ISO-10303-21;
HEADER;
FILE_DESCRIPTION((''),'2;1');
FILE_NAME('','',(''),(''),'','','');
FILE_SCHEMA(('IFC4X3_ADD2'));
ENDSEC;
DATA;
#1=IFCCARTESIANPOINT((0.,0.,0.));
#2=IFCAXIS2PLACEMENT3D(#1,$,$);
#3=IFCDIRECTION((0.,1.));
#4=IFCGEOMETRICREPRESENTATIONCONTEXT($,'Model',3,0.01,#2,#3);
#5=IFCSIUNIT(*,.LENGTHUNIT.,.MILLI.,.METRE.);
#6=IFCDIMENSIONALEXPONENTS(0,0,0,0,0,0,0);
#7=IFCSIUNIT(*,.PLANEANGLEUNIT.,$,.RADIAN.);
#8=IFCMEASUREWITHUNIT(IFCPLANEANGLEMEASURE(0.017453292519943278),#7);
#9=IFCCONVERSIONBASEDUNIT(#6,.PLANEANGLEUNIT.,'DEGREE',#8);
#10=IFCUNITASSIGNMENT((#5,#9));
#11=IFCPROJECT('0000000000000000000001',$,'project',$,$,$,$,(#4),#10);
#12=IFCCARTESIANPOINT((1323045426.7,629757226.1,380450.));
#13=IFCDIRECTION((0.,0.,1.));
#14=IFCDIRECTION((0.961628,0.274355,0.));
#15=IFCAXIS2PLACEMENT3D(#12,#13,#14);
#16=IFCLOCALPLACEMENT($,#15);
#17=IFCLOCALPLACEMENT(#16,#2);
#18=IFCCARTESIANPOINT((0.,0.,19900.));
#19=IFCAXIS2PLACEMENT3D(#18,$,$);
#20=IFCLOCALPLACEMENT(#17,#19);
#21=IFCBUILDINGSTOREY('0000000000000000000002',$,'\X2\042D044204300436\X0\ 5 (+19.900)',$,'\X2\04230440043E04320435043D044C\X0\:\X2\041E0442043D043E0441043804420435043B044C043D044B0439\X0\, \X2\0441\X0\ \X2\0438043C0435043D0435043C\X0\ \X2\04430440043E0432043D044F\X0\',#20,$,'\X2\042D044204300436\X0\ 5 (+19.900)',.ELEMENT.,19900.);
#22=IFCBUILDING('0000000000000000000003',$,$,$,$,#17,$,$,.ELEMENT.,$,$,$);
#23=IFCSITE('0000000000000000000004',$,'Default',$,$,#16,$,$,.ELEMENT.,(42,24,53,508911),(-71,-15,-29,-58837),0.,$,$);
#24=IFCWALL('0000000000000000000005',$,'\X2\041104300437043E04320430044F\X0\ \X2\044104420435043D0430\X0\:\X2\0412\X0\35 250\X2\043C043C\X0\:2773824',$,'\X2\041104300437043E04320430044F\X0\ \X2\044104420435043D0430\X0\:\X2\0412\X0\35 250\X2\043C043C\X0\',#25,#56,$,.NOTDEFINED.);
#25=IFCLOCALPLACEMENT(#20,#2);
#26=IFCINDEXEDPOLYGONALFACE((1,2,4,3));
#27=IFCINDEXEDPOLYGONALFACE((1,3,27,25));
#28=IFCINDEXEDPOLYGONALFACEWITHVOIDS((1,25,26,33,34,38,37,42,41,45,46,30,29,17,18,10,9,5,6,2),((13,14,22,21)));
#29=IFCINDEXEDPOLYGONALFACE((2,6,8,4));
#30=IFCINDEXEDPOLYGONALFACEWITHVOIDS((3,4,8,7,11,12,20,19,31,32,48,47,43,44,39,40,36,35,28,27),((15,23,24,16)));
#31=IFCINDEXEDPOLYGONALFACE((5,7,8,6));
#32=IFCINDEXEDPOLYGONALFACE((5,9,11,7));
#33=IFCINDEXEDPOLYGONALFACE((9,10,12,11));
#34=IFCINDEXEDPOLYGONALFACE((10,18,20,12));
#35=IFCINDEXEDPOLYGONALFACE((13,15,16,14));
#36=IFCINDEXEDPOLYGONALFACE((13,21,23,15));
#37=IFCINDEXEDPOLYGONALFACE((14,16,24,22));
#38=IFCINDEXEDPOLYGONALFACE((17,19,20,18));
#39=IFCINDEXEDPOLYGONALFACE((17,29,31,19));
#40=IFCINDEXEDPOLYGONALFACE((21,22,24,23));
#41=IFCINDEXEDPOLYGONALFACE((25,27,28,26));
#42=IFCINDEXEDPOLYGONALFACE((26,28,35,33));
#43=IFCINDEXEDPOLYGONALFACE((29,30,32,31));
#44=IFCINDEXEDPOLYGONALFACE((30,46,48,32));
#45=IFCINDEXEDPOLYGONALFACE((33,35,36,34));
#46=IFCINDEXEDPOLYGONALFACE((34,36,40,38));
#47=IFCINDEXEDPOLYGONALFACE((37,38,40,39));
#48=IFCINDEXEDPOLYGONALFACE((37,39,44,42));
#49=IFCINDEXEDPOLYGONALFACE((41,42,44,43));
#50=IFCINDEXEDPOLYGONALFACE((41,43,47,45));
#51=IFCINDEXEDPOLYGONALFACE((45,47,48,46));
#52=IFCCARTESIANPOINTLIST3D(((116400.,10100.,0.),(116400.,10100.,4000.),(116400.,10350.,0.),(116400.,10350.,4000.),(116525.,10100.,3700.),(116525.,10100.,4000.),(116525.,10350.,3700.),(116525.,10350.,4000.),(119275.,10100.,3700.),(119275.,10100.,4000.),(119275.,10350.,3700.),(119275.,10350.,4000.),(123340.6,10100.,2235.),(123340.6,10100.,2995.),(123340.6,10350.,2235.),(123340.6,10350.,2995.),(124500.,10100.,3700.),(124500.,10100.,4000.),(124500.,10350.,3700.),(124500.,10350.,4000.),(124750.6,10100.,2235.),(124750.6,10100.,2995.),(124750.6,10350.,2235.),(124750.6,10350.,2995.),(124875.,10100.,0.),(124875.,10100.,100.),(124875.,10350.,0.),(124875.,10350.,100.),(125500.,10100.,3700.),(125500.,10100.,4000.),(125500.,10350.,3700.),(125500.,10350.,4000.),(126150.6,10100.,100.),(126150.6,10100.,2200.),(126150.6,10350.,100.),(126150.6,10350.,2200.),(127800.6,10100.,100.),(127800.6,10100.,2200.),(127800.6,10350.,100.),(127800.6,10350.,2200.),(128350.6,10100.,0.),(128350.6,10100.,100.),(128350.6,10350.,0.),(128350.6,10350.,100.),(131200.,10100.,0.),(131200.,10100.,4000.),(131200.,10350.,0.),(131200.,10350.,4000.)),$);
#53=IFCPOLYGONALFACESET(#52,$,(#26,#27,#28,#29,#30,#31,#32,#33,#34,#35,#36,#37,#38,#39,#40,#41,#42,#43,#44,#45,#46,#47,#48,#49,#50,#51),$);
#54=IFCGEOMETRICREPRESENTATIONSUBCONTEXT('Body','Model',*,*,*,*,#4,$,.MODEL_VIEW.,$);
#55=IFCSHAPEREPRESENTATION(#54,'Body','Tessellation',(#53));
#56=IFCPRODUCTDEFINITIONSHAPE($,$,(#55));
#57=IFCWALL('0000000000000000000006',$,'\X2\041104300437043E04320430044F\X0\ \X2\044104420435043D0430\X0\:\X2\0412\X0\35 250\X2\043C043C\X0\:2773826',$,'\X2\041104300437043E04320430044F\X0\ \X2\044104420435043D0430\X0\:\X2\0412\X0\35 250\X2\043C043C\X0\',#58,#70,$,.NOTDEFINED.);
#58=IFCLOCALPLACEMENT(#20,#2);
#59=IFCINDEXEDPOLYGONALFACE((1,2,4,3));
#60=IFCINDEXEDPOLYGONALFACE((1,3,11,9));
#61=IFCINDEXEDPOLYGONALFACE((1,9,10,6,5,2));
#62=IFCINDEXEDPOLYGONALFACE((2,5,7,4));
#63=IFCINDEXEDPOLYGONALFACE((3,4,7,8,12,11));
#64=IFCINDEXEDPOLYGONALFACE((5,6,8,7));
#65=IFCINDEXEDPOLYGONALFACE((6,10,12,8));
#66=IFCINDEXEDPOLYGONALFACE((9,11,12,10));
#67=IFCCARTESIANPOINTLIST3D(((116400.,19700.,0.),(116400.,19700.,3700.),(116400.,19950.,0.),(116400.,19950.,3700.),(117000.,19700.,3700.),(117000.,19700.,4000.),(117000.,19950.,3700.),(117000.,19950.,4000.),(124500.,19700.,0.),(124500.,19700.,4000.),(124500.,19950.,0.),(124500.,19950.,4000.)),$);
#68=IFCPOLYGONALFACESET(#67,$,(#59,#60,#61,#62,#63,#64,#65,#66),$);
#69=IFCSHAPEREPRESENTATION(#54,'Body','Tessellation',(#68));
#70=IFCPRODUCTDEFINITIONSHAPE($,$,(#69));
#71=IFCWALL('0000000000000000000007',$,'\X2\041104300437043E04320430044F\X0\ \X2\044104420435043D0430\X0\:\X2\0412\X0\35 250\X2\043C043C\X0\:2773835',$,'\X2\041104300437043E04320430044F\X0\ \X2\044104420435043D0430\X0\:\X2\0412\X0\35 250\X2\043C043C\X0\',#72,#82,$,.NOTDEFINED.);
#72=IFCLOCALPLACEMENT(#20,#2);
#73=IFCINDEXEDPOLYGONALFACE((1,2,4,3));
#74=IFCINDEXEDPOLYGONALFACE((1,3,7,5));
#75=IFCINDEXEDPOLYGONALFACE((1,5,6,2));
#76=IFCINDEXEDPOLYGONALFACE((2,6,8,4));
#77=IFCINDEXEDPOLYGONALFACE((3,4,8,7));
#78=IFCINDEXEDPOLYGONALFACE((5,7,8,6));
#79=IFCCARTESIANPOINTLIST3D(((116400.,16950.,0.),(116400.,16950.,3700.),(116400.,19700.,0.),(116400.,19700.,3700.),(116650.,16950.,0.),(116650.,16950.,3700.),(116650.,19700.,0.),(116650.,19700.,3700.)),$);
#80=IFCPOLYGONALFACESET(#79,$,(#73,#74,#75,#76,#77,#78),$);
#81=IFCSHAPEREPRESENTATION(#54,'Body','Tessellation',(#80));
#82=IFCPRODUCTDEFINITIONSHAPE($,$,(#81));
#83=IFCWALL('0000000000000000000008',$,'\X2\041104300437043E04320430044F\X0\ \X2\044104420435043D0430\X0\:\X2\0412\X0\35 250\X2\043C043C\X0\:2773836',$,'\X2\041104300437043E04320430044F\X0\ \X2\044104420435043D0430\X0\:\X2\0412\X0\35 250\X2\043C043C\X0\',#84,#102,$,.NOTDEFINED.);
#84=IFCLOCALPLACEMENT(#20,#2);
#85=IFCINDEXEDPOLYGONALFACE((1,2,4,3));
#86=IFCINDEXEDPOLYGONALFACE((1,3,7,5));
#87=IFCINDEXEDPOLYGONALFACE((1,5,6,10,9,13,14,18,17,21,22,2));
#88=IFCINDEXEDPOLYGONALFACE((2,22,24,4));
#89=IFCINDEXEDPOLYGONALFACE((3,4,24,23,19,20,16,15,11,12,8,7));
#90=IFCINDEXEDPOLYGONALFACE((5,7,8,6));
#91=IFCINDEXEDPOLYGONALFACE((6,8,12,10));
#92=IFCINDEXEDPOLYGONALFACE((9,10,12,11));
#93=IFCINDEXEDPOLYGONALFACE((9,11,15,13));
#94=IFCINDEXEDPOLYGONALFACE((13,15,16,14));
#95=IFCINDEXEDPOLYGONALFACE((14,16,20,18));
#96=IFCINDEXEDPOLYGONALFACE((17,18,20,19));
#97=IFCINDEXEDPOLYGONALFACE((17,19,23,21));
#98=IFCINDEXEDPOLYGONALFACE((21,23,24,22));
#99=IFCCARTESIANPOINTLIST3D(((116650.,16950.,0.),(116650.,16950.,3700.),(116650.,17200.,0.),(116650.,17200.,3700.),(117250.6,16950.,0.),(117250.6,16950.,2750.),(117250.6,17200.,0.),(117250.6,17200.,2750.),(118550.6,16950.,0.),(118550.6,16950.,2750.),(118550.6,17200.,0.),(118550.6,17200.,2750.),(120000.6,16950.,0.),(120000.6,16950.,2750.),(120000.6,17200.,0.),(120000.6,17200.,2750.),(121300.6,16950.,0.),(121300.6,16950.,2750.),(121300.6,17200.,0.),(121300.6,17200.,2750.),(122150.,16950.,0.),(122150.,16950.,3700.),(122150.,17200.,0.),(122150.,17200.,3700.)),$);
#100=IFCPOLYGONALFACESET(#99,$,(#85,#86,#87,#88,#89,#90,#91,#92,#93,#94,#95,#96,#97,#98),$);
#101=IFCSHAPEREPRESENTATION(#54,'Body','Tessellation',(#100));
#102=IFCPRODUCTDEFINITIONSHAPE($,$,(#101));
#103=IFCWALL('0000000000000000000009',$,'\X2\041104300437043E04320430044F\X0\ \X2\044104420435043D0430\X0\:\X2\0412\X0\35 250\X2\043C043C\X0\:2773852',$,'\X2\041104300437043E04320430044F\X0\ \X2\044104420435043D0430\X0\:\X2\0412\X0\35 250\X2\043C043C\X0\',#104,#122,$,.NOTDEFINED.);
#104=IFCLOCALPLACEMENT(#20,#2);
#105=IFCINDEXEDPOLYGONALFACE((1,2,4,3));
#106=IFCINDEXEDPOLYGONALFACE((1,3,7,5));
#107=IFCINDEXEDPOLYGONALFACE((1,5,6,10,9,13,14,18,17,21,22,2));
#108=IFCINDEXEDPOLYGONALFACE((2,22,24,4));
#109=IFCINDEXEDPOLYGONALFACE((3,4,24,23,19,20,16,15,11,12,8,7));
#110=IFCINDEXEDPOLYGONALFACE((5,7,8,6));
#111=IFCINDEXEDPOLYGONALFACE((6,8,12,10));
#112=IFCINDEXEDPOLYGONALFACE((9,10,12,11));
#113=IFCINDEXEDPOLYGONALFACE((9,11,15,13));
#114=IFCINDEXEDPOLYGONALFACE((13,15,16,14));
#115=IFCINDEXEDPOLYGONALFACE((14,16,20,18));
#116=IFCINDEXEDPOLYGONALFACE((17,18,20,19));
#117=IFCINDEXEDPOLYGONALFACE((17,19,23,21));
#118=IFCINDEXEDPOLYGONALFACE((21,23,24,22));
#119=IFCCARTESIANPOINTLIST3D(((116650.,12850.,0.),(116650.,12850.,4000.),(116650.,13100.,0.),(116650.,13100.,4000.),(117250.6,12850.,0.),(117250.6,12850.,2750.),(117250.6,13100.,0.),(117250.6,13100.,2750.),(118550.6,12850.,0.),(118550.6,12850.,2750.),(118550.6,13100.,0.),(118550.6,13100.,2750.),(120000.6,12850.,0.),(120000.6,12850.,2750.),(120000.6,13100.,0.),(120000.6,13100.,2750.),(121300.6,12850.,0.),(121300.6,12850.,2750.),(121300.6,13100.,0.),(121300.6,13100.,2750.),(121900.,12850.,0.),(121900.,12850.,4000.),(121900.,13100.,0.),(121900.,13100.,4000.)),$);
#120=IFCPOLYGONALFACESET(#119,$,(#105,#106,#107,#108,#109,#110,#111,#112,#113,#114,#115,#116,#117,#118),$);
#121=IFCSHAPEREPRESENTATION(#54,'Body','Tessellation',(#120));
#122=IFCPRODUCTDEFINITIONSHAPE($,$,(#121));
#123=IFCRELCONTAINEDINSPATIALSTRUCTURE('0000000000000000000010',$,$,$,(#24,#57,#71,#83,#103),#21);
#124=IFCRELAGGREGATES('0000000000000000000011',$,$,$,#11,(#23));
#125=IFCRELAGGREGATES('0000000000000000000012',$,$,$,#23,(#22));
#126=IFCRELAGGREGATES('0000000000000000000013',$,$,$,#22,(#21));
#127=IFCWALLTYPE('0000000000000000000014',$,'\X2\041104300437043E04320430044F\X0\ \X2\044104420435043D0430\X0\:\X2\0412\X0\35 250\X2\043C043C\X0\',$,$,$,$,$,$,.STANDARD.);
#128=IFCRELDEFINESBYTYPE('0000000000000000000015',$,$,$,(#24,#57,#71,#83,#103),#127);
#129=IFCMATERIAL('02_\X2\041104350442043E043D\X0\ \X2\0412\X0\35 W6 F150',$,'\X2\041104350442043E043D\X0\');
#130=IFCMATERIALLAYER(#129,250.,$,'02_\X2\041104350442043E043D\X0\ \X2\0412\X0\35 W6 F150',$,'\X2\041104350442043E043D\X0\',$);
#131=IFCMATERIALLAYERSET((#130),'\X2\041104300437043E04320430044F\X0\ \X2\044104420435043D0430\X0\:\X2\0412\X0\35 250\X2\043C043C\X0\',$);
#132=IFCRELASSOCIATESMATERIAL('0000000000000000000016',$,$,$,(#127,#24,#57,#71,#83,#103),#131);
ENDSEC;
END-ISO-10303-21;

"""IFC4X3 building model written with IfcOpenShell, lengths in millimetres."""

from ifc_helpers import new_model, entity, si_unit, converted_unit, direction, frame, frame_2d, origin, origin_2d_with_axis, place, context, subcontext, project, spatial, rectangle, extrude, material, layer, layer_set, type_object, element, save


model = new_model("IFC4X3")

# Units and contexts
model_context = context("Model", 3, precision=0.01, world=origin(), true_north=direction((0.0, 1.0)))
body_context = subcontext(model_context, "Body", "Model", "MODEL_VIEW")
ifc_project = project(units=[si_unit("LENGTHUNIT", "METRE", prefix="MILLI"), converted_unit("PLANEANGLEUNIT", "DEGREE", entity("IfcPlaneAngleMeasure", 0.017453292519943278), si_unit("PLANEANGLEUNIT", "RADIAN"), dimensions=[0, 0, 0, 0, 0, 0, 0])], contexts=[model_context])

# Site, building, storey
site_placement = place(None, frame((1323045426.7, 629757226.1, 380450.0), z_axis=(0.0, 0.0, 1.0), x_axis=(0.961628, 0.274355, 0.0)))
site = spatial("IfcSite", under=ifc_project, at=site_placement, Name="Default", CompositionType="ELEMENT", RefLatitude=(42, 24, 53, 508911), RefLongitude=(-71, -15, -29, -58837), RefElevation=0.0)
building_placement = place(site_placement, origin())
building = spatial("IfcBuilding", under=site, at=building_placement, CompositionType="ELEMENT")
storey_placement = place(building_placement, frame((0.0, 0.0, 19900.0)))
storey = spatial("IfcBuildingStorey", under=building, at=storey_placement, Name="Этаж 5 (+19.900)", ObjectType="Уровень:Относительный, с именем уровня", LongName="Этаж 5 (+19.900)", CompositionType="ELEMENT", Elevation=19900.0)

# Shared definitions
ifc_material = material(Name="02_Бетон В35 W6 F150", Category="Бетон")

# Wall, openings
ifc_layer_1 = layer(ifc_material, 250.0, Name="02_Бетон В35 W6 F150", Category="Бетон")
ifc_layer_set_1 = layer_set([ifc_layer_1], Name="Базовая стена:В35 250мм")
wall_type_1 = type_object("IfcWallType", Name="Базовая стена:В35 250мм", PredefinedType="STANDARD", material=ifc_layer_set_1)
wall_1_placement = place(storey_placement, frame((116400.0, 10225.0, 0.0)))
wall_1 = element("IfcWall", 1, at=wall_1_placement, inside=storey, type_object=wall_type_1, material=ifc_layer_set_1, Name="Базовая стена:В35 250мм:2773824", ObjectType="Базовая стена:В35 250мм", PredefinedType="NOTDEFINED", context=body_context, shape_type="SweptSolid", body=[
    extrude(rectangle(XDim=14800.0, YDim=250.0, at=frame_2d((7400.0, 0.0), x_axis=(-1.0, 0.0))), origin(), (0.0, 0.0, 1.0), 4000.0),
])
opening_1_placement = place(wall_1_placement, origin())
element("IfcOpeningElement", 2, at=opening_1_placement, cuts=wall_1, PredefinedType="OPENING", context=body_context, shape_type="SweptSolid", body=[
    extrude(rectangle(XDim=300.0, YDim=1000.0, at=frame_2d((0.0, 0.0), x_axis=(1.0, 0.0))), frame((8600.0, 125.0, 3850.0), z_axis=(0.0, -1.0, 0.0), x_axis=(0.0, 0.0, -1.0)), (0.0, 0.0, 1.0), 250.0),
])
opening_2_placement = place(wall_1_placement, origin())
element("IfcOpeningElement", 3, at=opening_2_placement, cuts=wall_1, PredefinedType="OPENING", context=body_context, shape_type="SweptSolid", body=[
    extrude(rectangle(XDim=100.0, YDim=3475.6, at=origin_2d_with_axis()), frame((10212.8, 125.0, 50.0), z_axis=(0.0, -1.0, 0.0), x_axis=(0.0, 0.0, 1.0)), (0.0, 0.0, 1.0), 250.0),
])
opening_3_placement = place(wall_1_placement, origin())
element("IfcOpeningElement", 4, at=opening_3_placement, cuts=wall_1, PredefinedType="OPENING", context=body_context, shape_type="SweptSolid", body=[
    extrude(rectangle(XDim=300.0, YDim=2750.0, at=frame_2d((0.0, 0.0), x_axis=(0.0, 1.0))), frame((1500.0, 125.0, 3850.0), z_axis=(0.0, -1.0, 0.0), x_axis=(1.0, 0.0, 0.0)), (0.0, 0.0, 1.0), 250.0),
])
opening_4_placement = place(wall_1_placement, frame((-116400.0, -10225.0, 0.0)))
element("IfcOpeningElement", 5, at=opening_4_placement, cuts=wall_1, PredefinedType="OPENING", context=body_context, shape_type="SweptSolid", body=[
    extrude(rectangle(XDim=2200.0, YDim=1650.0, at=frame_2d((0.0, 0.0), x_axis=(0.0, 1.0))), frame((126975.6, 8826.0, 1100.0), z_axis=(0.0, 1.0, 0.0), x_axis=(1.0, 0.0, 0.0)), (0.0, 0.0, 1.0), 3048.0),
])
opening_5_placement = place(wall_1_placement, frame((-116400.0, -10225.0, 2235.0)))
element("IfcOpeningElement", 6, at=opening_5_placement, cuts=wall_1, PredefinedType="OPENING", context=body_context, shape_type="SweptSolid", body=[
    extrude(rectangle(XDim=760.0, YDim=1410.0, at=frame_2d((0.0, 0.0), x_axis=(0.0, 1.0))), frame((124045.6, 8576.0, 380.0), z_axis=(0.0, 1.0, 0.0), x_axis=(1.0, 0.0, 0.0)), (0.0, 0.0, 1.0), 3048.0),
])

# Wall, opening
wall_2_placement = place(storey_placement, frame((116400.0, 19825.0, 0.0)))
wall_2 = element("IfcWall", 7, at=wall_2_placement, inside=storey, type_object=wall_type_1, material=ifc_layer_set_1, Name="Базовая стена:В35 250мм:2773826", ObjectType="Базовая стена:В35 250мм", PredefinedType="NOTDEFINED", context=body_context, shape_type="SweptSolid", body=[
    extrude(rectangle(XDim=8100.0, YDim=250.0, at=frame_2d((4050.0, 0.0), x_axis=(-1.0, 0.0))), origin(), (0.0, 0.0, 1.0), 4000.0),
])
opening_6_placement = place(wall_2_placement, origin())
element("IfcOpeningElement", 8, at=opening_6_placement, cuts=wall_2, PredefinedType="OPENING", context=body_context, shape_type="SweptSolid", body=[
    extrude(rectangle(XDim=300.0, YDim=600.0, at=frame_2d((0.0, 0.0), x_axis=(0.0, 1.0))), frame((300.0, 125.0, 3850.0), z_axis=(0.0, -1.0, 0.0), x_axis=(-1.0, 0.0, 0.0)), (0.0, 0.0, 1.0), 250.0),
])

# Wall
wall_3_placement = place(storey_placement, frame((116525.0, 16950.0, 0.0), z_axis=(0.0, 0.0, 1.0), x_axis=(0.0, 1.0, 0.0)))
element("IfcWall", 9, at=wall_3_placement, inside=storey, type_object=wall_type_1, material=ifc_layer_set_1, Name="Базовая стена:В35 250мм:2773835", ObjectType="Базовая стена:В35 250мм", PredefinedType="NOTDEFINED", context=body_context, shape_type="SweptSolid", body=[
    extrude(rectangle(XDim=2750.0, YDim=250.0, at=frame_2d((1375.0, 0.0), x_axis=(-1.0, 0.0))), origin(), (0.0, 0.0, 1.0), 3700.0),
])

# Walls, openings
wall_4_placement = place(storey_placement, frame((116650.0, 17075.0, 0.0)))
wall_4 = element("IfcWall", 10, at=wall_4_placement, inside=storey, type_object=wall_type_1, material=ifc_layer_set_1, Name="Базовая стена:В35 250мм:2773836", ObjectType="Базовая стена:В35 250мм", PredefinedType="NOTDEFINED", context=body_context, shape_type="SweptSolid", body=[
    extrude(rectangle(XDim=5500.0, YDim=250.0, at=frame_2d((2750.0, 0.0), x_axis=(1.0, 0.0))), origin(), (0.0, 0.0, 1.0), 3700.0),
])
opening_7_placement = place(wall_4_placement, frame((-116650.0, -17075.0, 0.0)))
element("IfcOpeningElement", 11, at=opening_7_placement, cuts=wall_4, PredefinedType="OPENING", context=body_context, shape_type="SweptSolid", body=[
    extrude(rectangle(XDim=2750.0, YDim=1300.0, at=frame_2d((0.0, 0.0), x_axis=(0.0, 1.0))), frame((117900.6, 15676.0, 1375.0), z_axis=(0.0, 1.0, 0.0), x_axis=(1.0, 0.0, 0.0)), (0.0, 0.0, 1.0), 3048.0),
])
opening_8_placement = place(wall_4_placement, frame((-116650.0, -17075.0, 0.0)))
element("IfcOpeningElement", 12, at=opening_8_placement, cuts=wall_4, PredefinedType="OPENING", context=body_context, shape_type="SweptSolid", body=[
    extrude(rectangle(XDim=2750.0, YDim=1300.0, at=frame_2d((0.0, 0.0), x_axis=(0.0, 1.0))), frame((120650.6, 15676.0, 1375.0), z_axis=(0.0, 1.0, 0.0), x_axis=(1.0, 0.0, 0.0)), (0.0, 0.0, 1.0), 3048.0),
])
wall_5_placement = place(storey_placement, frame((116650.0, 12975.0, 0.0)))
wall_5 = element("IfcWall", 13, at=wall_5_placement, inside=storey, type_object=wall_type_1, material=ifc_layer_set_1, Name="Базовая стена:В35 250мм:2773852", ObjectType="Базовая стена:В35 250мм", PredefinedType="NOTDEFINED", context=body_context, shape_type="SweptSolid", body=[
    extrude(rectangle(XDim=5250.0, YDim=250.0, at=frame_2d((2625.0, 0.0), x_axis=(1.0, 0.0))), origin(), (0.0, 0.0, 1.0), 4000.0),
])
opening_9_placement = place(wall_5_placement, frame((-116650.0, -12975.0, 0.0)))
element("IfcOpeningElement", 14, at=opening_9_placement, cuts=wall_5, PredefinedType="OPENING", context=body_context, shape_type="SweptSolid", body=[
    extrude(rectangle(XDim=2750.0, YDim=1300.0, at=frame_2d((0.0, 0.0), x_axis=(0.0, 1.0))), frame((117900.6, 11576.0, 1375.0), z_axis=(0.0, 1.0, 0.0), x_axis=(1.0, 0.0, 0.0)), (0.0, 0.0, 1.0), 3048.0),
])
opening_10_placement = place(wall_5_placement, frame((-116650.0, -12975.0, 0.0)))
element("IfcOpeningElement", 15, at=opening_10_placement, cuts=wall_5, PredefinedType="OPENING", context=body_context, shape_type="SweptSolid", body=[
    extrude(rectangle(XDim=2750.0, YDim=1300.0, at=frame_2d((0.0, 0.0), x_axis=(0.0, 1.0))), frame((120650.6, 11576.0, 1375.0), z_axis=(0.0, 1.0, 0.0), x_axis=(1.0, 0.0, 0.0)), (0.0, 0.0, 1.0), 3048.0),
])

save(model, "model.ifc")
